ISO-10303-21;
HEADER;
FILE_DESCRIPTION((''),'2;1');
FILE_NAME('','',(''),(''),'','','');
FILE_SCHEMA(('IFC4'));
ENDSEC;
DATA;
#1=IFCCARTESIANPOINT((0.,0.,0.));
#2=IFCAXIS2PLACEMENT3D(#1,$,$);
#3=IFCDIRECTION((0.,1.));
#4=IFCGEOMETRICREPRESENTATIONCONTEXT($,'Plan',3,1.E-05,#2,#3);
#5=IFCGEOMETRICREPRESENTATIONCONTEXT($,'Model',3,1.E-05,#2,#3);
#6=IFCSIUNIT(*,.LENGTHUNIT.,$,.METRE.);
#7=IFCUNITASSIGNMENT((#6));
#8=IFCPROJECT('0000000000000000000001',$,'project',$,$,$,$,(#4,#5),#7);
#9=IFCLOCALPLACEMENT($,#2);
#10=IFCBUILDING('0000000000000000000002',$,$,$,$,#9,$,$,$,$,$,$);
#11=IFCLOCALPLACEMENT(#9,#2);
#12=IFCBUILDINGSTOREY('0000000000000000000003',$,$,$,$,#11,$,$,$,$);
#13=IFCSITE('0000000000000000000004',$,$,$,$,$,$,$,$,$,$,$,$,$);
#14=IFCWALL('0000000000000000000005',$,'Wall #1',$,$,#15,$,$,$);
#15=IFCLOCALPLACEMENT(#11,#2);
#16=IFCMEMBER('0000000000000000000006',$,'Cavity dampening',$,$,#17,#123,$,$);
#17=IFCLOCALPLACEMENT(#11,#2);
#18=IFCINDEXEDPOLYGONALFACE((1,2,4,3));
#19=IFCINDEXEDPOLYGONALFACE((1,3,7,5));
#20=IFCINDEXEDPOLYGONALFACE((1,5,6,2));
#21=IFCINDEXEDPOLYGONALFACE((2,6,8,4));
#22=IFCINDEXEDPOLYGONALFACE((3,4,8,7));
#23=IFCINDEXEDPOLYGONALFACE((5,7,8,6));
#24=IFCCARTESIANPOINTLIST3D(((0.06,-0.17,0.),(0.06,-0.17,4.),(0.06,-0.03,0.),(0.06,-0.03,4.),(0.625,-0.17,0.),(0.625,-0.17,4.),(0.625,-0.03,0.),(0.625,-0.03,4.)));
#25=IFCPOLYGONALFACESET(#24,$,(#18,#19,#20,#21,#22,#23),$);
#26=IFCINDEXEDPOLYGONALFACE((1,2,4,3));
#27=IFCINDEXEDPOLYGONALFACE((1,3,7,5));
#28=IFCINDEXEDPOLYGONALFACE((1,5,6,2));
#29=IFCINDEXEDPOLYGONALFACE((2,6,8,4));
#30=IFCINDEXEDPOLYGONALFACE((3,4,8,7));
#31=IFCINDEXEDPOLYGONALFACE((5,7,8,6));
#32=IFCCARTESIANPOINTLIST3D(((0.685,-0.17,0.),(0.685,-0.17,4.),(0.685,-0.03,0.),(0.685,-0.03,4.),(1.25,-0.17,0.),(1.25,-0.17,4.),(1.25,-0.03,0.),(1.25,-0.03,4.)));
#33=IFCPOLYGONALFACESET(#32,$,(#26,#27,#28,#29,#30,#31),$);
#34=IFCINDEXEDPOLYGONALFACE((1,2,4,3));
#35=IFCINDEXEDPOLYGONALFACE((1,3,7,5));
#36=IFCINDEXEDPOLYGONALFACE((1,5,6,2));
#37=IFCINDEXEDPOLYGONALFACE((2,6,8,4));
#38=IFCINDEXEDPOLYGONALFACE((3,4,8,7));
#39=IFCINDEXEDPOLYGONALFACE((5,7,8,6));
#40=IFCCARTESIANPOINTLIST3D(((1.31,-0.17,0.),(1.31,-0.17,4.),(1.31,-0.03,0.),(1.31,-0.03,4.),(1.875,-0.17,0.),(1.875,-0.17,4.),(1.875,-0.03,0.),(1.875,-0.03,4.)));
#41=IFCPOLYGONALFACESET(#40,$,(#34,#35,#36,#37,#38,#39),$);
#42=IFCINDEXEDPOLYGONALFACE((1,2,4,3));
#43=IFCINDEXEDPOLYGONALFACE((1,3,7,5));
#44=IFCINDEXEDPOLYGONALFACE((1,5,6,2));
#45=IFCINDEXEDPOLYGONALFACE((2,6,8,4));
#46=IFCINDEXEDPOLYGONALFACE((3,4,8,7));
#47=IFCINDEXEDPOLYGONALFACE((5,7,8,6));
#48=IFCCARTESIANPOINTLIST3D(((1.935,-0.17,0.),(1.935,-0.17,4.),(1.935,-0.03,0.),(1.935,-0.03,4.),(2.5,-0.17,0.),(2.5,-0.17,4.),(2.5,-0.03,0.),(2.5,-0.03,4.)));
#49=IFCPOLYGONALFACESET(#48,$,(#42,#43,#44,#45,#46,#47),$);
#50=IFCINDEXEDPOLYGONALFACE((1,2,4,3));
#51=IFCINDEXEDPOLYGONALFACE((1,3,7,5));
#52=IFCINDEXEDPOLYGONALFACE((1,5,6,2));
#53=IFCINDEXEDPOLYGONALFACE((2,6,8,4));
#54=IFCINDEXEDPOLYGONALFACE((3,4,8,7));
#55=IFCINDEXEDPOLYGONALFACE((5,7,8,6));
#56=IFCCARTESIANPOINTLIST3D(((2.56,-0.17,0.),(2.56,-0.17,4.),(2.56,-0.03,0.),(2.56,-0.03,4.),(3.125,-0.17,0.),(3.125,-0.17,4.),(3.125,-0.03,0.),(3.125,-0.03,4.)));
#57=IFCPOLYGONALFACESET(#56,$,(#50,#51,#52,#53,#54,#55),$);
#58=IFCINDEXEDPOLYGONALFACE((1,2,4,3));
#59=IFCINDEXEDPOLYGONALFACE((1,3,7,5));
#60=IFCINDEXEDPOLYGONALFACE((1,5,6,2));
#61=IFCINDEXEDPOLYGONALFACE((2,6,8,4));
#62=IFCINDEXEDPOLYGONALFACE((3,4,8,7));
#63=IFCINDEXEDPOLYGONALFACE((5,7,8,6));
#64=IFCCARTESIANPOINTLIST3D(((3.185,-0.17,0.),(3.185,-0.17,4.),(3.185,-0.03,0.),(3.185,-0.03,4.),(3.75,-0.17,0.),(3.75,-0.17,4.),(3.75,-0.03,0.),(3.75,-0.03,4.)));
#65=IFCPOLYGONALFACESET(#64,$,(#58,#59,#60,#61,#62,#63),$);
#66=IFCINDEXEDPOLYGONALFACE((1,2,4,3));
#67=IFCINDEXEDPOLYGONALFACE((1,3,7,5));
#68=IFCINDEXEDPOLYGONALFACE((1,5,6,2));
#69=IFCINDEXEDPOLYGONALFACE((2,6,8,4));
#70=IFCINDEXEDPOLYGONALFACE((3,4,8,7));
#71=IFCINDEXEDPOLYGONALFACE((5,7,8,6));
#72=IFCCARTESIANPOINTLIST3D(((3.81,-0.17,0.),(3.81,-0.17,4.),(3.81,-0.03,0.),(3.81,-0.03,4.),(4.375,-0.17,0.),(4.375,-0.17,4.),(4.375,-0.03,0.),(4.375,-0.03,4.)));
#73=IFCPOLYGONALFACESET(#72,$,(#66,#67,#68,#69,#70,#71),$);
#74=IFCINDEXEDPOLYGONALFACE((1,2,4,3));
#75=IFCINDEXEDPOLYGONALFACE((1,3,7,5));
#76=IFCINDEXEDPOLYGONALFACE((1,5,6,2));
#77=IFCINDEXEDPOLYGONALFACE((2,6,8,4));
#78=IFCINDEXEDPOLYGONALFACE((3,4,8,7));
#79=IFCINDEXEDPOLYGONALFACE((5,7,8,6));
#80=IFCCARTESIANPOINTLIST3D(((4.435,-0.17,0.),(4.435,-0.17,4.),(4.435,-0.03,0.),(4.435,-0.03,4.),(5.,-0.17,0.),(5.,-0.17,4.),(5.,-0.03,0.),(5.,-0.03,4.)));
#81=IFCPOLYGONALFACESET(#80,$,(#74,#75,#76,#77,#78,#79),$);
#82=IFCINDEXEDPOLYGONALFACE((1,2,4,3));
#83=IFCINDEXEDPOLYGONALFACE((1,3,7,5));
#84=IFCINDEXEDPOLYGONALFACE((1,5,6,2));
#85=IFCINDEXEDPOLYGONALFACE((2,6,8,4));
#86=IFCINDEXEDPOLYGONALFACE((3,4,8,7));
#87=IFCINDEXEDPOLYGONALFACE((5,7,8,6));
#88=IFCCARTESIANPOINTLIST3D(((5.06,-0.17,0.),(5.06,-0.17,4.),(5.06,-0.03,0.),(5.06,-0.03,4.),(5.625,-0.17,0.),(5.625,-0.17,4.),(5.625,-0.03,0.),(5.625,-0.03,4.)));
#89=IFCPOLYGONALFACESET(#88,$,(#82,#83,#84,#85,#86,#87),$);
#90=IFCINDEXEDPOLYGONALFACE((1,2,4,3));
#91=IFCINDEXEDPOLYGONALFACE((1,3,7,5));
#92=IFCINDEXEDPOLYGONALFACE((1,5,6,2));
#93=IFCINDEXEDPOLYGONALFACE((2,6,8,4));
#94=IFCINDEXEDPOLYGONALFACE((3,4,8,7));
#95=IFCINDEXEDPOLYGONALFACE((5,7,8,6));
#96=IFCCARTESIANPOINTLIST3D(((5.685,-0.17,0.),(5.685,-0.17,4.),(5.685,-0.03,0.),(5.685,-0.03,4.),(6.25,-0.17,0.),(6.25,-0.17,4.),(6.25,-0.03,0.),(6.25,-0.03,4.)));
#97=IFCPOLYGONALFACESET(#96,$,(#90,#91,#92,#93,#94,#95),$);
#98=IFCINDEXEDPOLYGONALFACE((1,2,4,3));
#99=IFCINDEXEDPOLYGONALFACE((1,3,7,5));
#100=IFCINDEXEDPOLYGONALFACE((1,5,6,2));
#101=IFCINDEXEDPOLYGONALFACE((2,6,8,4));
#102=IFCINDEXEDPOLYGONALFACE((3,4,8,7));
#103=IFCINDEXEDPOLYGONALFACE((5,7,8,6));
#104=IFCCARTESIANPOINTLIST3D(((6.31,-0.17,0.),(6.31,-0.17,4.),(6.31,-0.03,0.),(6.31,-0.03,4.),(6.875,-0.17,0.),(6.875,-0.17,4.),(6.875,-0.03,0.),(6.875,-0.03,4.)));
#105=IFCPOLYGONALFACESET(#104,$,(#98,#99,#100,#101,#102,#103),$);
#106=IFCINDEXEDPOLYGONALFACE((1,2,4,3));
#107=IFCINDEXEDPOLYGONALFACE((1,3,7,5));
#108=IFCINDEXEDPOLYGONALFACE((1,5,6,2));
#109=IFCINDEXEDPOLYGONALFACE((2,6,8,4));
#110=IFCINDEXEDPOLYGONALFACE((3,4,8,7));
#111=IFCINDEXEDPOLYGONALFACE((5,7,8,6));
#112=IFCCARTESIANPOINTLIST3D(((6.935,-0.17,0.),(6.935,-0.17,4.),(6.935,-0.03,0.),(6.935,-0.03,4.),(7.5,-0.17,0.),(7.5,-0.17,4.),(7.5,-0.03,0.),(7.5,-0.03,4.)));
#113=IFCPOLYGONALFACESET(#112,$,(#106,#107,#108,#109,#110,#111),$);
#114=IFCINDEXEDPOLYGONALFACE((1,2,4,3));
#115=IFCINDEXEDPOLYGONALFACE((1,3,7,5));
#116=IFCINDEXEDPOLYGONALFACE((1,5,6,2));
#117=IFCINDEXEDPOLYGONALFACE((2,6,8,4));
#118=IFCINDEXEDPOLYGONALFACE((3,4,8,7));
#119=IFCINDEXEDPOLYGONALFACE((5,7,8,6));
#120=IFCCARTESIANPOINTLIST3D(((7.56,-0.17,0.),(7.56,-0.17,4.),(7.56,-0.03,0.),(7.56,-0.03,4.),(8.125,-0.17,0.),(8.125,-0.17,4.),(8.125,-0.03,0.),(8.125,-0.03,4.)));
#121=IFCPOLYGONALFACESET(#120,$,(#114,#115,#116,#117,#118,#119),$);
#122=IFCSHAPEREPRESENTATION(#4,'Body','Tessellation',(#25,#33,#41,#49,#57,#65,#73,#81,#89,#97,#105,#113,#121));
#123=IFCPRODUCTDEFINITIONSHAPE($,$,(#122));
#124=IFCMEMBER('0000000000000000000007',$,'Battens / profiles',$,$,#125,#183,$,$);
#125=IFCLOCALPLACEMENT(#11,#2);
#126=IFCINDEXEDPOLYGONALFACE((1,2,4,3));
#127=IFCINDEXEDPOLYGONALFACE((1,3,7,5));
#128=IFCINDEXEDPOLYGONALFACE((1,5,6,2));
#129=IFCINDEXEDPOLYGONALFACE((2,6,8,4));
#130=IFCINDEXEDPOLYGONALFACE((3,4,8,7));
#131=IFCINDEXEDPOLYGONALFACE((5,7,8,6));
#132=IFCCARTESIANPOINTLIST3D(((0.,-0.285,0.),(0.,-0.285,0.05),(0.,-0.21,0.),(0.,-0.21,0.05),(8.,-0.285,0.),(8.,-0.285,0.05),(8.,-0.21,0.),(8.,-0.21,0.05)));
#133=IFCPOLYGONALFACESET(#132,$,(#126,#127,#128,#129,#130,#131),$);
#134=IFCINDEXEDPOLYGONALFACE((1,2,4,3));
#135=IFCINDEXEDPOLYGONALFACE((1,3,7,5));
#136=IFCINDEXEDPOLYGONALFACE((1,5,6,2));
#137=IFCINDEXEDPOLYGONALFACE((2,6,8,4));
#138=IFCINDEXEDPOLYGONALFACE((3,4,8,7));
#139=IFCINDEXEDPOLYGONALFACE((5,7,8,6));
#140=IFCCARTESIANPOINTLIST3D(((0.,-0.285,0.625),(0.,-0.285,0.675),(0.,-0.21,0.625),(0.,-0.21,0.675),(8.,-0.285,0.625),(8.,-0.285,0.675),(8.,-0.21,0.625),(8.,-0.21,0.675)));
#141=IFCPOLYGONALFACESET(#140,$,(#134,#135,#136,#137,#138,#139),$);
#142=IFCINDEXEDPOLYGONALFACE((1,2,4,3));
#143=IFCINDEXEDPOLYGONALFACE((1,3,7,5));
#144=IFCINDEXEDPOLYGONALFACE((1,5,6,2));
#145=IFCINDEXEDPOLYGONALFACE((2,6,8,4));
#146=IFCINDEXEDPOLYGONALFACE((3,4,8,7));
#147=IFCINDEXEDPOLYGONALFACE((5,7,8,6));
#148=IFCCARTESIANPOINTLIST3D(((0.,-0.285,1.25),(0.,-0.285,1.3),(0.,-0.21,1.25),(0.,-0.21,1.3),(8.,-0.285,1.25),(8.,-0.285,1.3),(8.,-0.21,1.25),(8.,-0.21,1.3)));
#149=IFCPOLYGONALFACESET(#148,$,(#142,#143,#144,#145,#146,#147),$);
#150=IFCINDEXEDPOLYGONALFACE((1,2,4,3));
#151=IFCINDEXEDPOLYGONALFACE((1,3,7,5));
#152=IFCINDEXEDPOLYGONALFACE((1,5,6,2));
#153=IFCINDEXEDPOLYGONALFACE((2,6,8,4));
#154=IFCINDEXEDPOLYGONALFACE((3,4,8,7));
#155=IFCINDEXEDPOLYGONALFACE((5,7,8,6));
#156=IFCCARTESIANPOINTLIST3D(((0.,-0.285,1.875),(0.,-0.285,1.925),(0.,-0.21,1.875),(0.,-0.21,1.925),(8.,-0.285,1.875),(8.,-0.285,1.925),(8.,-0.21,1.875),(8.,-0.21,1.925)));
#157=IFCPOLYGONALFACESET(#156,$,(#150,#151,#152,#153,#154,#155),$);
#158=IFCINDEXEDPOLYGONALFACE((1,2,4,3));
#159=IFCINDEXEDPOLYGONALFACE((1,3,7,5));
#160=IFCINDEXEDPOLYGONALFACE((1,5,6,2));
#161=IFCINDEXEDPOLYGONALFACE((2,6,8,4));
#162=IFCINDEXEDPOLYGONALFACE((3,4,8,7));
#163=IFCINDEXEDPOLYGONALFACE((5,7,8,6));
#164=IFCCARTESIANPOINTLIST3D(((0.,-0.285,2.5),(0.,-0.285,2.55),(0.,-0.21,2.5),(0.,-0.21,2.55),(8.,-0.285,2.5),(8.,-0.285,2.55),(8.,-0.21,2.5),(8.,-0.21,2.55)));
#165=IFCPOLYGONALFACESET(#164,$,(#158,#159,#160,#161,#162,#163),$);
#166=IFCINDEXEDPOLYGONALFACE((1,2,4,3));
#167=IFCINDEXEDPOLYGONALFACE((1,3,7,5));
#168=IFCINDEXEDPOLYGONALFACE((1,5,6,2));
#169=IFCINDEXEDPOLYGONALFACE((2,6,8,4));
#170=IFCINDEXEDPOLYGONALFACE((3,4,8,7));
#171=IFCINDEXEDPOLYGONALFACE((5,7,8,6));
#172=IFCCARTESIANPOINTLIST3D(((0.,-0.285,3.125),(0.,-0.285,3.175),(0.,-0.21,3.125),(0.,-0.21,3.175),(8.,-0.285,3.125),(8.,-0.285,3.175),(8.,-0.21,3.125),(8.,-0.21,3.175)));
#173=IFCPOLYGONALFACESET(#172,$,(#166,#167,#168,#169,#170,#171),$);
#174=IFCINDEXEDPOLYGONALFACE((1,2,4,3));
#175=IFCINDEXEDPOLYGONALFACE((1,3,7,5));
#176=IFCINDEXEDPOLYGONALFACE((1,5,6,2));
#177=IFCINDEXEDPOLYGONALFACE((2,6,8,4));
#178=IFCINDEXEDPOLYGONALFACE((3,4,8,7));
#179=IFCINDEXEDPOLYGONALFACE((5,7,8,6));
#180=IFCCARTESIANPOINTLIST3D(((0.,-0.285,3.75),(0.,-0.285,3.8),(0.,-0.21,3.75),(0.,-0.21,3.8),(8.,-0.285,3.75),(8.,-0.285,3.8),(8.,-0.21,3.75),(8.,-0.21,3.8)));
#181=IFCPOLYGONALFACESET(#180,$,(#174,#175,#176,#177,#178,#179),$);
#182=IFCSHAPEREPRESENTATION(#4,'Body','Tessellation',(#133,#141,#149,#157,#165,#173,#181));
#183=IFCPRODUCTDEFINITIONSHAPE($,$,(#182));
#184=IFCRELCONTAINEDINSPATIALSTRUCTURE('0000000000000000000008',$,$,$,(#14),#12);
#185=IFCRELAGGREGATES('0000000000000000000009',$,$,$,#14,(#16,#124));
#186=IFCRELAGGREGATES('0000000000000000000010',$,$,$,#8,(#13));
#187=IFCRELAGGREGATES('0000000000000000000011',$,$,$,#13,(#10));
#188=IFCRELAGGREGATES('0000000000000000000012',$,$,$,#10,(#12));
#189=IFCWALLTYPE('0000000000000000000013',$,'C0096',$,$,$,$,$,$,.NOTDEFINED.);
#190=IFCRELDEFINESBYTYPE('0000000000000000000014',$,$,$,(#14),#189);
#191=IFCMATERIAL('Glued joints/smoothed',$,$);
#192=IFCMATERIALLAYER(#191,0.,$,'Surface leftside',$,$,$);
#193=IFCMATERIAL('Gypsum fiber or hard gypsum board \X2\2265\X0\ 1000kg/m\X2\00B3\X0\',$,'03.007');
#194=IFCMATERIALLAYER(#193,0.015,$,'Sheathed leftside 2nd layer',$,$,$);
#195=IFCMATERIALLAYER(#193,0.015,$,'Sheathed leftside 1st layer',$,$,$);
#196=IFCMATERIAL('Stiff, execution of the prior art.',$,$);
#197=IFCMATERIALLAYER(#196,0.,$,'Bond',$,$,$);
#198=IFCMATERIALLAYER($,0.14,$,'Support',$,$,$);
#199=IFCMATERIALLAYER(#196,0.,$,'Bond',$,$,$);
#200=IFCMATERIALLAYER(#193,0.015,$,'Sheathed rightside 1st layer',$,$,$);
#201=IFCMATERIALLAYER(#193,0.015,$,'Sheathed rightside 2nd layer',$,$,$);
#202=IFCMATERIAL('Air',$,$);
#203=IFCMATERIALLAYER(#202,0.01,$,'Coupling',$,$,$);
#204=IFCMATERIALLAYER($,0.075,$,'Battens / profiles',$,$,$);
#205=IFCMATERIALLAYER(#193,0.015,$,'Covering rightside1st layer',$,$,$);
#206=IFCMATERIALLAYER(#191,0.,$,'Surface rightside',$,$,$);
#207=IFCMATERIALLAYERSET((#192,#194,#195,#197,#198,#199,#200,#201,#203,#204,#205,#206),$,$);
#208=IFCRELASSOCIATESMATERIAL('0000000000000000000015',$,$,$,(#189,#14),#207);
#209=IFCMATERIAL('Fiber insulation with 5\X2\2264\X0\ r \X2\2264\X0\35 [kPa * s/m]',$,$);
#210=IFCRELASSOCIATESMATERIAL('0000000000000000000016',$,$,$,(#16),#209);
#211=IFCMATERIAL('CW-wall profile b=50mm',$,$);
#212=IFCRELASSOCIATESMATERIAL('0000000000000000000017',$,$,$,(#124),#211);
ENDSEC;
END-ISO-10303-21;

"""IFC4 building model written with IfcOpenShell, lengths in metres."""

from ifc_helpers import new_model, si_unit, direction, frame, frame_2d, origin, place, context, project, spatial, rectangle, extrude, material, layer, layer_set, type_object, element, aggregate, save


model = new_model("IFC4")

# Units and contexts
plan_context = context("Plan", 3, precision=1e-05, world=origin(), true_north=direction((0.0, 1.0)))
model_context = context("Model", 3, precision=1e-05, world=origin(), true_north=direction((0.0, 1.0)))
ifc_project = project(units=[si_unit("LENGTHUNIT", "METRE")], contexts=[plan_context, model_context])

# Site, building, storey
site = spatial("IfcSite", under=ifc_project)
building_placement = place(None, origin())
building = spatial("IfcBuilding", under=site, at=building_placement)
storey_placement = place(building_placement, origin())
storey = spatial("IfcBuildingStorey", under=building, at=storey_placement)

# Wall, members
ifc_material_1 = material(Name="Glued joints/smoothed")
ifc_layer_1 = layer(ifc_material_1, 0.0, Name="Surface leftside")
ifc_material_2 = material(Name="Gypsum fiber or hard gypsum board ≥ 1000kg/m³", Category="03.007")
ifc_layer_2 = layer(ifc_material_2, 0.015, Name="Sheathed leftside 2nd layer")
ifc_layer_3 = layer(ifc_material_2, 0.015, Name="Sheathed leftside 1st layer")
ifc_material_3 = material(Name="Stiff, execution of the prior art.")
ifc_layer_4 = layer(ifc_material_3, 0.0, Name="Bond")
ifc_layer_5 = layer(None, 0.14, Name="Support")
ifc_layer_6 = layer(ifc_material_3, 0.0, Name="Bond")
ifc_layer_7 = layer(ifc_material_2, 0.015, Name="Sheathed rightside 1st layer")
ifc_layer_8 = layer(ifc_material_2, 0.015, Name="Sheathed rightside 2nd layer")
ifc_material_4 = material(Name="Air")
ifc_layer_9 = layer(ifc_material_4, 0.01, Name="Coupling")
ifc_layer_10 = layer(None, 0.075, Name="Battens / profiles")
ifc_layer_11 = layer(ifc_material_2, 0.015, Name="Covering rightside1st layer")
ifc_layer_12 = layer(ifc_material_1, 0.0, Name="Surface rightside")
ifc_layer_set = layer_set([ifc_layer_1, ifc_layer_2, ifc_layer_3, ifc_layer_4, ifc_layer_5, ifc_layer_6, ifc_layer_7, ifc_layer_8, ifc_layer_9, ifc_layer_10, ifc_layer_11, ifc_layer_12])
wall_type = type_object("IfcWallType", Name="C0096", PredefinedType="NOTDEFINED", material=ifc_layer_set)
wall_placement = place(None, frame((0.0, 0.0, 0.0), z_axis=(0.0, -1.0, 0.0), x_axis=(1.0, 0.0, 0.0)))
wall = element("IfcWall", 1, at=wall_placement, inside=storey, type_object=wall_type, material=ifc_layer_set, Name="Wall #1")
ifc_material_5 = material(Name="Fiber insulation with 5≤ r ≤35 [kPa * s/m]")
member_1_placement = place(wall_placement, origin())
member_1 = element("IfcMember", 2, at=member_1_placement, material=ifc_material_5, Name="Cavity dampening", context=plan_context, shape_type="SweptSolid", body=[
    extrude(rectangle(XDim=0.565, YDim=0.14, at=frame_2d((0.2825, 0.07), x_axis=(1.0, 0.0))), frame((0.06, 4.0, 0.03), z_axis=(0.0, -1.0, 0.0), x_axis=(1.0, 0.0, 0.0)), (0.0, 0.0, 1.0), 4.0),
    extrude(rectangle(XDim=0.565, YDim=0.14, at=frame_2d((0.2825, 0.07), x_axis=(1.0, 0.0))), frame((0.685, 4.0, 0.03), z_axis=(0.0, -1.0, 0.0), x_axis=(1.0, 0.0, 0.0)), (0.0, 0.0, 1.0), 4.0),
    extrude(rectangle(XDim=0.565, YDim=0.14, at=frame_2d((0.2825, 0.07), x_axis=(1.0, 0.0))), frame((1.31, 4.0, 0.03), z_axis=(0.0, -1.0, 0.0), x_axis=(1.0, 0.0, 0.0)), (0.0, 0.0, 1.0), 4.0),
    extrude(rectangle(XDim=0.565, YDim=0.14, at=frame_2d((0.2825, 0.07), x_axis=(1.0, 0.0))), frame((1.935, 4.0, 0.03), z_axis=(0.0, -1.0, 0.0), x_axis=(1.0, 0.0, 0.0)), (0.0, 0.0, 1.0), 4.0),
    extrude(rectangle(XDim=0.565, YDim=0.14, at=frame_2d((0.2825, 0.07), x_axis=(1.0, 0.0))), frame((2.56, 4.0, 0.03), z_axis=(0.0, -1.0, 0.0), x_axis=(1.0, 0.0, 0.0)), (0.0, 0.0, 1.0), 4.0),
    extrude(rectangle(XDim=0.565, YDim=0.14, at=frame_2d((0.2825, 0.07), x_axis=(1.0, 0.0))), frame((3.185, 4.0, 0.03), z_axis=(0.0, -1.0, 0.0), x_axis=(1.0, 0.0, 0.0)), (0.0, 0.0, 1.0), 4.0),
    extrude(rectangle(XDim=0.565, YDim=0.14, at=frame_2d((0.2825, 0.07), x_axis=(1.0, 0.0))), frame((3.81, 4.0, 0.03), z_axis=(0.0, -1.0, 0.0), x_axis=(1.0, 0.0, 0.0)), (0.0, 0.0, 1.0), 4.0),
    extrude(rectangle(XDim=0.565, YDim=0.14, at=frame_2d((0.2825, 0.07), x_axis=(1.0, 0.0))), frame((4.435, 4.0, 0.03), z_axis=(0.0, -1.0, 0.0), x_axis=(1.0, 0.0, 0.0)), (0.0, 0.0, 1.0), 4.0),
    extrude(rectangle(XDim=0.565, YDim=0.14, at=frame_2d((0.2825, 0.07), x_axis=(1.0, 0.0))), frame((5.06, 4.0, 0.03), z_axis=(0.0, -1.0, 0.0), x_axis=(1.0, 0.0, 0.0)), (0.0, 0.0, 1.0), 4.0),
    extrude(rectangle(XDim=0.565, YDim=0.14, at=frame_2d((0.2825, 0.07), x_axis=(1.0, 0.0))), frame((5.685, 4.0, 0.03), z_axis=(0.0, -1.0, 0.0), x_axis=(1.0, 0.0, 0.0)), (0.0, 0.0, 1.0), 4.0),
    extrude(rectangle(XDim=0.565, YDim=0.14, at=frame_2d((0.2825, 0.07), x_axis=(1.0, 0.0))), frame((6.31, 4.0, 0.03), z_axis=(0.0, -1.0, 0.0), x_axis=(1.0, 0.0, 0.0)), (0.0, 0.0, 1.0), 4.0),
    extrude(rectangle(XDim=0.565, YDim=0.14, at=frame_2d((0.2825, 0.07), x_axis=(1.0, 0.0))), frame((6.935, 4.0, 0.03), z_axis=(0.0, -1.0, 0.0), x_axis=(1.0, 0.0, 0.0)), (0.0, 0.0, 1.0), 4.0),
    extrude(rectangle(XDim=0.565, YDim=0.14, at=frame_2d((0.2825, 0.07), x_axis=(1.0, 0.0))), frame((7.56, 4.0, 0.03), z_axis=(0.0, -1.0, 0.0), x_axis=(1.0, 0.0, 0.0)), (0.0, 0.0, 1.0), 4.0),
])
ifc_material_6 = material(Name="CW-wall profile b=50mm")
member_2_placement = place(wall_placement, origin())
member_2 = element("IfcMember", 3, at=member_2_placement, material=ifc_material_6, Name="Battens / profiles", context=plan_context, shape_type="SweptSolid", body=[
    extrude(rectangle(XDim=0.05, YDim=0.075, at=frame_2d((0.025, 0.0375), x_axis=(1.0, 0.0))), frame((0.0, 0.0, 0.21), z_axis=(1.0, 0.0, 0.0), x_axis=(0.0, 1.0, 0.0)), (0.0, 0.0, 1.0), 8.0),
    extrude(rectangle(XDim=0.05, YDim=0.075, at=frame_2d((0.025, 0.0375), x_axis=(1.0, 0.0))), frame((0.0, 0.625, 0.21), z_axis=(1.0, 0.0, 0.0), x_axis=(0.0, 1.0, 0.0)), (0.0, 0.0, 1.0), 8.0),
    extrude(rectangle(XDim=0.05, YDim=0.075, at=frame_2d((0.025, 0.0375), x_axis=(1.0, 0.0))), frame((0.0, 1.25, 0.21), z_axis=(1.0, 0.0, 0.0), x_axis=(0.0, 1.0, 0.0)), (0.0, 0.0, 1.0), 8.0),
    extrude(rectangle(XDim=0.05, YDim=0.075, at=frame_2d((0.025, 0.0375), x_axis=(1.0, 0.0))), frame((0.0, 1.875, 0.21), z_axis=(1.0, 0.0, 0.0), x_axis=(0.0, 1.0, 0.0)), (0.0, 0.0, 1.0), 8.0),
    extrude(rectangle(XDim=0.05, YDim=0.075, at=frame_2d((0.025, 0.0375), x_axis=(1.0, 0.0))), frame((0.0, 2.5, 0.21), z_axis=(1.0, 0.0, 0.0), x_axis=(0.0, 1.0, 0.0)), (0.0, 0.0, 1.0), 8.0),
    extrude(rectangle(XDim=0.05, YDim=0.075, at=frame_2d((0.025, 0.0375), x_axis=(1.0, 0.0))), frame((0.0, 3.125, 0.21), z_axis=(1.0, 0.0, 0.0), x_axis=(0.0, 1.0, 0.0)), (0.0, 0.0, 1.0), 8.0),
    extrude(rectangle(XDim=0.05, YDim=0.075, at=frame_2d((0.025, 0.0375), x_axis=(1.0, 0.0))), frame((0.0, 3.75, 0.21), z_axis=(1.0, 0.0, 0.0), x_axis=(0.0, 1.0, 0.0)), (0.0, 0.0, 1.0), 8.0),
])
aggregate(wall, [member_1, member_2])

save(model, "model.ifc")
